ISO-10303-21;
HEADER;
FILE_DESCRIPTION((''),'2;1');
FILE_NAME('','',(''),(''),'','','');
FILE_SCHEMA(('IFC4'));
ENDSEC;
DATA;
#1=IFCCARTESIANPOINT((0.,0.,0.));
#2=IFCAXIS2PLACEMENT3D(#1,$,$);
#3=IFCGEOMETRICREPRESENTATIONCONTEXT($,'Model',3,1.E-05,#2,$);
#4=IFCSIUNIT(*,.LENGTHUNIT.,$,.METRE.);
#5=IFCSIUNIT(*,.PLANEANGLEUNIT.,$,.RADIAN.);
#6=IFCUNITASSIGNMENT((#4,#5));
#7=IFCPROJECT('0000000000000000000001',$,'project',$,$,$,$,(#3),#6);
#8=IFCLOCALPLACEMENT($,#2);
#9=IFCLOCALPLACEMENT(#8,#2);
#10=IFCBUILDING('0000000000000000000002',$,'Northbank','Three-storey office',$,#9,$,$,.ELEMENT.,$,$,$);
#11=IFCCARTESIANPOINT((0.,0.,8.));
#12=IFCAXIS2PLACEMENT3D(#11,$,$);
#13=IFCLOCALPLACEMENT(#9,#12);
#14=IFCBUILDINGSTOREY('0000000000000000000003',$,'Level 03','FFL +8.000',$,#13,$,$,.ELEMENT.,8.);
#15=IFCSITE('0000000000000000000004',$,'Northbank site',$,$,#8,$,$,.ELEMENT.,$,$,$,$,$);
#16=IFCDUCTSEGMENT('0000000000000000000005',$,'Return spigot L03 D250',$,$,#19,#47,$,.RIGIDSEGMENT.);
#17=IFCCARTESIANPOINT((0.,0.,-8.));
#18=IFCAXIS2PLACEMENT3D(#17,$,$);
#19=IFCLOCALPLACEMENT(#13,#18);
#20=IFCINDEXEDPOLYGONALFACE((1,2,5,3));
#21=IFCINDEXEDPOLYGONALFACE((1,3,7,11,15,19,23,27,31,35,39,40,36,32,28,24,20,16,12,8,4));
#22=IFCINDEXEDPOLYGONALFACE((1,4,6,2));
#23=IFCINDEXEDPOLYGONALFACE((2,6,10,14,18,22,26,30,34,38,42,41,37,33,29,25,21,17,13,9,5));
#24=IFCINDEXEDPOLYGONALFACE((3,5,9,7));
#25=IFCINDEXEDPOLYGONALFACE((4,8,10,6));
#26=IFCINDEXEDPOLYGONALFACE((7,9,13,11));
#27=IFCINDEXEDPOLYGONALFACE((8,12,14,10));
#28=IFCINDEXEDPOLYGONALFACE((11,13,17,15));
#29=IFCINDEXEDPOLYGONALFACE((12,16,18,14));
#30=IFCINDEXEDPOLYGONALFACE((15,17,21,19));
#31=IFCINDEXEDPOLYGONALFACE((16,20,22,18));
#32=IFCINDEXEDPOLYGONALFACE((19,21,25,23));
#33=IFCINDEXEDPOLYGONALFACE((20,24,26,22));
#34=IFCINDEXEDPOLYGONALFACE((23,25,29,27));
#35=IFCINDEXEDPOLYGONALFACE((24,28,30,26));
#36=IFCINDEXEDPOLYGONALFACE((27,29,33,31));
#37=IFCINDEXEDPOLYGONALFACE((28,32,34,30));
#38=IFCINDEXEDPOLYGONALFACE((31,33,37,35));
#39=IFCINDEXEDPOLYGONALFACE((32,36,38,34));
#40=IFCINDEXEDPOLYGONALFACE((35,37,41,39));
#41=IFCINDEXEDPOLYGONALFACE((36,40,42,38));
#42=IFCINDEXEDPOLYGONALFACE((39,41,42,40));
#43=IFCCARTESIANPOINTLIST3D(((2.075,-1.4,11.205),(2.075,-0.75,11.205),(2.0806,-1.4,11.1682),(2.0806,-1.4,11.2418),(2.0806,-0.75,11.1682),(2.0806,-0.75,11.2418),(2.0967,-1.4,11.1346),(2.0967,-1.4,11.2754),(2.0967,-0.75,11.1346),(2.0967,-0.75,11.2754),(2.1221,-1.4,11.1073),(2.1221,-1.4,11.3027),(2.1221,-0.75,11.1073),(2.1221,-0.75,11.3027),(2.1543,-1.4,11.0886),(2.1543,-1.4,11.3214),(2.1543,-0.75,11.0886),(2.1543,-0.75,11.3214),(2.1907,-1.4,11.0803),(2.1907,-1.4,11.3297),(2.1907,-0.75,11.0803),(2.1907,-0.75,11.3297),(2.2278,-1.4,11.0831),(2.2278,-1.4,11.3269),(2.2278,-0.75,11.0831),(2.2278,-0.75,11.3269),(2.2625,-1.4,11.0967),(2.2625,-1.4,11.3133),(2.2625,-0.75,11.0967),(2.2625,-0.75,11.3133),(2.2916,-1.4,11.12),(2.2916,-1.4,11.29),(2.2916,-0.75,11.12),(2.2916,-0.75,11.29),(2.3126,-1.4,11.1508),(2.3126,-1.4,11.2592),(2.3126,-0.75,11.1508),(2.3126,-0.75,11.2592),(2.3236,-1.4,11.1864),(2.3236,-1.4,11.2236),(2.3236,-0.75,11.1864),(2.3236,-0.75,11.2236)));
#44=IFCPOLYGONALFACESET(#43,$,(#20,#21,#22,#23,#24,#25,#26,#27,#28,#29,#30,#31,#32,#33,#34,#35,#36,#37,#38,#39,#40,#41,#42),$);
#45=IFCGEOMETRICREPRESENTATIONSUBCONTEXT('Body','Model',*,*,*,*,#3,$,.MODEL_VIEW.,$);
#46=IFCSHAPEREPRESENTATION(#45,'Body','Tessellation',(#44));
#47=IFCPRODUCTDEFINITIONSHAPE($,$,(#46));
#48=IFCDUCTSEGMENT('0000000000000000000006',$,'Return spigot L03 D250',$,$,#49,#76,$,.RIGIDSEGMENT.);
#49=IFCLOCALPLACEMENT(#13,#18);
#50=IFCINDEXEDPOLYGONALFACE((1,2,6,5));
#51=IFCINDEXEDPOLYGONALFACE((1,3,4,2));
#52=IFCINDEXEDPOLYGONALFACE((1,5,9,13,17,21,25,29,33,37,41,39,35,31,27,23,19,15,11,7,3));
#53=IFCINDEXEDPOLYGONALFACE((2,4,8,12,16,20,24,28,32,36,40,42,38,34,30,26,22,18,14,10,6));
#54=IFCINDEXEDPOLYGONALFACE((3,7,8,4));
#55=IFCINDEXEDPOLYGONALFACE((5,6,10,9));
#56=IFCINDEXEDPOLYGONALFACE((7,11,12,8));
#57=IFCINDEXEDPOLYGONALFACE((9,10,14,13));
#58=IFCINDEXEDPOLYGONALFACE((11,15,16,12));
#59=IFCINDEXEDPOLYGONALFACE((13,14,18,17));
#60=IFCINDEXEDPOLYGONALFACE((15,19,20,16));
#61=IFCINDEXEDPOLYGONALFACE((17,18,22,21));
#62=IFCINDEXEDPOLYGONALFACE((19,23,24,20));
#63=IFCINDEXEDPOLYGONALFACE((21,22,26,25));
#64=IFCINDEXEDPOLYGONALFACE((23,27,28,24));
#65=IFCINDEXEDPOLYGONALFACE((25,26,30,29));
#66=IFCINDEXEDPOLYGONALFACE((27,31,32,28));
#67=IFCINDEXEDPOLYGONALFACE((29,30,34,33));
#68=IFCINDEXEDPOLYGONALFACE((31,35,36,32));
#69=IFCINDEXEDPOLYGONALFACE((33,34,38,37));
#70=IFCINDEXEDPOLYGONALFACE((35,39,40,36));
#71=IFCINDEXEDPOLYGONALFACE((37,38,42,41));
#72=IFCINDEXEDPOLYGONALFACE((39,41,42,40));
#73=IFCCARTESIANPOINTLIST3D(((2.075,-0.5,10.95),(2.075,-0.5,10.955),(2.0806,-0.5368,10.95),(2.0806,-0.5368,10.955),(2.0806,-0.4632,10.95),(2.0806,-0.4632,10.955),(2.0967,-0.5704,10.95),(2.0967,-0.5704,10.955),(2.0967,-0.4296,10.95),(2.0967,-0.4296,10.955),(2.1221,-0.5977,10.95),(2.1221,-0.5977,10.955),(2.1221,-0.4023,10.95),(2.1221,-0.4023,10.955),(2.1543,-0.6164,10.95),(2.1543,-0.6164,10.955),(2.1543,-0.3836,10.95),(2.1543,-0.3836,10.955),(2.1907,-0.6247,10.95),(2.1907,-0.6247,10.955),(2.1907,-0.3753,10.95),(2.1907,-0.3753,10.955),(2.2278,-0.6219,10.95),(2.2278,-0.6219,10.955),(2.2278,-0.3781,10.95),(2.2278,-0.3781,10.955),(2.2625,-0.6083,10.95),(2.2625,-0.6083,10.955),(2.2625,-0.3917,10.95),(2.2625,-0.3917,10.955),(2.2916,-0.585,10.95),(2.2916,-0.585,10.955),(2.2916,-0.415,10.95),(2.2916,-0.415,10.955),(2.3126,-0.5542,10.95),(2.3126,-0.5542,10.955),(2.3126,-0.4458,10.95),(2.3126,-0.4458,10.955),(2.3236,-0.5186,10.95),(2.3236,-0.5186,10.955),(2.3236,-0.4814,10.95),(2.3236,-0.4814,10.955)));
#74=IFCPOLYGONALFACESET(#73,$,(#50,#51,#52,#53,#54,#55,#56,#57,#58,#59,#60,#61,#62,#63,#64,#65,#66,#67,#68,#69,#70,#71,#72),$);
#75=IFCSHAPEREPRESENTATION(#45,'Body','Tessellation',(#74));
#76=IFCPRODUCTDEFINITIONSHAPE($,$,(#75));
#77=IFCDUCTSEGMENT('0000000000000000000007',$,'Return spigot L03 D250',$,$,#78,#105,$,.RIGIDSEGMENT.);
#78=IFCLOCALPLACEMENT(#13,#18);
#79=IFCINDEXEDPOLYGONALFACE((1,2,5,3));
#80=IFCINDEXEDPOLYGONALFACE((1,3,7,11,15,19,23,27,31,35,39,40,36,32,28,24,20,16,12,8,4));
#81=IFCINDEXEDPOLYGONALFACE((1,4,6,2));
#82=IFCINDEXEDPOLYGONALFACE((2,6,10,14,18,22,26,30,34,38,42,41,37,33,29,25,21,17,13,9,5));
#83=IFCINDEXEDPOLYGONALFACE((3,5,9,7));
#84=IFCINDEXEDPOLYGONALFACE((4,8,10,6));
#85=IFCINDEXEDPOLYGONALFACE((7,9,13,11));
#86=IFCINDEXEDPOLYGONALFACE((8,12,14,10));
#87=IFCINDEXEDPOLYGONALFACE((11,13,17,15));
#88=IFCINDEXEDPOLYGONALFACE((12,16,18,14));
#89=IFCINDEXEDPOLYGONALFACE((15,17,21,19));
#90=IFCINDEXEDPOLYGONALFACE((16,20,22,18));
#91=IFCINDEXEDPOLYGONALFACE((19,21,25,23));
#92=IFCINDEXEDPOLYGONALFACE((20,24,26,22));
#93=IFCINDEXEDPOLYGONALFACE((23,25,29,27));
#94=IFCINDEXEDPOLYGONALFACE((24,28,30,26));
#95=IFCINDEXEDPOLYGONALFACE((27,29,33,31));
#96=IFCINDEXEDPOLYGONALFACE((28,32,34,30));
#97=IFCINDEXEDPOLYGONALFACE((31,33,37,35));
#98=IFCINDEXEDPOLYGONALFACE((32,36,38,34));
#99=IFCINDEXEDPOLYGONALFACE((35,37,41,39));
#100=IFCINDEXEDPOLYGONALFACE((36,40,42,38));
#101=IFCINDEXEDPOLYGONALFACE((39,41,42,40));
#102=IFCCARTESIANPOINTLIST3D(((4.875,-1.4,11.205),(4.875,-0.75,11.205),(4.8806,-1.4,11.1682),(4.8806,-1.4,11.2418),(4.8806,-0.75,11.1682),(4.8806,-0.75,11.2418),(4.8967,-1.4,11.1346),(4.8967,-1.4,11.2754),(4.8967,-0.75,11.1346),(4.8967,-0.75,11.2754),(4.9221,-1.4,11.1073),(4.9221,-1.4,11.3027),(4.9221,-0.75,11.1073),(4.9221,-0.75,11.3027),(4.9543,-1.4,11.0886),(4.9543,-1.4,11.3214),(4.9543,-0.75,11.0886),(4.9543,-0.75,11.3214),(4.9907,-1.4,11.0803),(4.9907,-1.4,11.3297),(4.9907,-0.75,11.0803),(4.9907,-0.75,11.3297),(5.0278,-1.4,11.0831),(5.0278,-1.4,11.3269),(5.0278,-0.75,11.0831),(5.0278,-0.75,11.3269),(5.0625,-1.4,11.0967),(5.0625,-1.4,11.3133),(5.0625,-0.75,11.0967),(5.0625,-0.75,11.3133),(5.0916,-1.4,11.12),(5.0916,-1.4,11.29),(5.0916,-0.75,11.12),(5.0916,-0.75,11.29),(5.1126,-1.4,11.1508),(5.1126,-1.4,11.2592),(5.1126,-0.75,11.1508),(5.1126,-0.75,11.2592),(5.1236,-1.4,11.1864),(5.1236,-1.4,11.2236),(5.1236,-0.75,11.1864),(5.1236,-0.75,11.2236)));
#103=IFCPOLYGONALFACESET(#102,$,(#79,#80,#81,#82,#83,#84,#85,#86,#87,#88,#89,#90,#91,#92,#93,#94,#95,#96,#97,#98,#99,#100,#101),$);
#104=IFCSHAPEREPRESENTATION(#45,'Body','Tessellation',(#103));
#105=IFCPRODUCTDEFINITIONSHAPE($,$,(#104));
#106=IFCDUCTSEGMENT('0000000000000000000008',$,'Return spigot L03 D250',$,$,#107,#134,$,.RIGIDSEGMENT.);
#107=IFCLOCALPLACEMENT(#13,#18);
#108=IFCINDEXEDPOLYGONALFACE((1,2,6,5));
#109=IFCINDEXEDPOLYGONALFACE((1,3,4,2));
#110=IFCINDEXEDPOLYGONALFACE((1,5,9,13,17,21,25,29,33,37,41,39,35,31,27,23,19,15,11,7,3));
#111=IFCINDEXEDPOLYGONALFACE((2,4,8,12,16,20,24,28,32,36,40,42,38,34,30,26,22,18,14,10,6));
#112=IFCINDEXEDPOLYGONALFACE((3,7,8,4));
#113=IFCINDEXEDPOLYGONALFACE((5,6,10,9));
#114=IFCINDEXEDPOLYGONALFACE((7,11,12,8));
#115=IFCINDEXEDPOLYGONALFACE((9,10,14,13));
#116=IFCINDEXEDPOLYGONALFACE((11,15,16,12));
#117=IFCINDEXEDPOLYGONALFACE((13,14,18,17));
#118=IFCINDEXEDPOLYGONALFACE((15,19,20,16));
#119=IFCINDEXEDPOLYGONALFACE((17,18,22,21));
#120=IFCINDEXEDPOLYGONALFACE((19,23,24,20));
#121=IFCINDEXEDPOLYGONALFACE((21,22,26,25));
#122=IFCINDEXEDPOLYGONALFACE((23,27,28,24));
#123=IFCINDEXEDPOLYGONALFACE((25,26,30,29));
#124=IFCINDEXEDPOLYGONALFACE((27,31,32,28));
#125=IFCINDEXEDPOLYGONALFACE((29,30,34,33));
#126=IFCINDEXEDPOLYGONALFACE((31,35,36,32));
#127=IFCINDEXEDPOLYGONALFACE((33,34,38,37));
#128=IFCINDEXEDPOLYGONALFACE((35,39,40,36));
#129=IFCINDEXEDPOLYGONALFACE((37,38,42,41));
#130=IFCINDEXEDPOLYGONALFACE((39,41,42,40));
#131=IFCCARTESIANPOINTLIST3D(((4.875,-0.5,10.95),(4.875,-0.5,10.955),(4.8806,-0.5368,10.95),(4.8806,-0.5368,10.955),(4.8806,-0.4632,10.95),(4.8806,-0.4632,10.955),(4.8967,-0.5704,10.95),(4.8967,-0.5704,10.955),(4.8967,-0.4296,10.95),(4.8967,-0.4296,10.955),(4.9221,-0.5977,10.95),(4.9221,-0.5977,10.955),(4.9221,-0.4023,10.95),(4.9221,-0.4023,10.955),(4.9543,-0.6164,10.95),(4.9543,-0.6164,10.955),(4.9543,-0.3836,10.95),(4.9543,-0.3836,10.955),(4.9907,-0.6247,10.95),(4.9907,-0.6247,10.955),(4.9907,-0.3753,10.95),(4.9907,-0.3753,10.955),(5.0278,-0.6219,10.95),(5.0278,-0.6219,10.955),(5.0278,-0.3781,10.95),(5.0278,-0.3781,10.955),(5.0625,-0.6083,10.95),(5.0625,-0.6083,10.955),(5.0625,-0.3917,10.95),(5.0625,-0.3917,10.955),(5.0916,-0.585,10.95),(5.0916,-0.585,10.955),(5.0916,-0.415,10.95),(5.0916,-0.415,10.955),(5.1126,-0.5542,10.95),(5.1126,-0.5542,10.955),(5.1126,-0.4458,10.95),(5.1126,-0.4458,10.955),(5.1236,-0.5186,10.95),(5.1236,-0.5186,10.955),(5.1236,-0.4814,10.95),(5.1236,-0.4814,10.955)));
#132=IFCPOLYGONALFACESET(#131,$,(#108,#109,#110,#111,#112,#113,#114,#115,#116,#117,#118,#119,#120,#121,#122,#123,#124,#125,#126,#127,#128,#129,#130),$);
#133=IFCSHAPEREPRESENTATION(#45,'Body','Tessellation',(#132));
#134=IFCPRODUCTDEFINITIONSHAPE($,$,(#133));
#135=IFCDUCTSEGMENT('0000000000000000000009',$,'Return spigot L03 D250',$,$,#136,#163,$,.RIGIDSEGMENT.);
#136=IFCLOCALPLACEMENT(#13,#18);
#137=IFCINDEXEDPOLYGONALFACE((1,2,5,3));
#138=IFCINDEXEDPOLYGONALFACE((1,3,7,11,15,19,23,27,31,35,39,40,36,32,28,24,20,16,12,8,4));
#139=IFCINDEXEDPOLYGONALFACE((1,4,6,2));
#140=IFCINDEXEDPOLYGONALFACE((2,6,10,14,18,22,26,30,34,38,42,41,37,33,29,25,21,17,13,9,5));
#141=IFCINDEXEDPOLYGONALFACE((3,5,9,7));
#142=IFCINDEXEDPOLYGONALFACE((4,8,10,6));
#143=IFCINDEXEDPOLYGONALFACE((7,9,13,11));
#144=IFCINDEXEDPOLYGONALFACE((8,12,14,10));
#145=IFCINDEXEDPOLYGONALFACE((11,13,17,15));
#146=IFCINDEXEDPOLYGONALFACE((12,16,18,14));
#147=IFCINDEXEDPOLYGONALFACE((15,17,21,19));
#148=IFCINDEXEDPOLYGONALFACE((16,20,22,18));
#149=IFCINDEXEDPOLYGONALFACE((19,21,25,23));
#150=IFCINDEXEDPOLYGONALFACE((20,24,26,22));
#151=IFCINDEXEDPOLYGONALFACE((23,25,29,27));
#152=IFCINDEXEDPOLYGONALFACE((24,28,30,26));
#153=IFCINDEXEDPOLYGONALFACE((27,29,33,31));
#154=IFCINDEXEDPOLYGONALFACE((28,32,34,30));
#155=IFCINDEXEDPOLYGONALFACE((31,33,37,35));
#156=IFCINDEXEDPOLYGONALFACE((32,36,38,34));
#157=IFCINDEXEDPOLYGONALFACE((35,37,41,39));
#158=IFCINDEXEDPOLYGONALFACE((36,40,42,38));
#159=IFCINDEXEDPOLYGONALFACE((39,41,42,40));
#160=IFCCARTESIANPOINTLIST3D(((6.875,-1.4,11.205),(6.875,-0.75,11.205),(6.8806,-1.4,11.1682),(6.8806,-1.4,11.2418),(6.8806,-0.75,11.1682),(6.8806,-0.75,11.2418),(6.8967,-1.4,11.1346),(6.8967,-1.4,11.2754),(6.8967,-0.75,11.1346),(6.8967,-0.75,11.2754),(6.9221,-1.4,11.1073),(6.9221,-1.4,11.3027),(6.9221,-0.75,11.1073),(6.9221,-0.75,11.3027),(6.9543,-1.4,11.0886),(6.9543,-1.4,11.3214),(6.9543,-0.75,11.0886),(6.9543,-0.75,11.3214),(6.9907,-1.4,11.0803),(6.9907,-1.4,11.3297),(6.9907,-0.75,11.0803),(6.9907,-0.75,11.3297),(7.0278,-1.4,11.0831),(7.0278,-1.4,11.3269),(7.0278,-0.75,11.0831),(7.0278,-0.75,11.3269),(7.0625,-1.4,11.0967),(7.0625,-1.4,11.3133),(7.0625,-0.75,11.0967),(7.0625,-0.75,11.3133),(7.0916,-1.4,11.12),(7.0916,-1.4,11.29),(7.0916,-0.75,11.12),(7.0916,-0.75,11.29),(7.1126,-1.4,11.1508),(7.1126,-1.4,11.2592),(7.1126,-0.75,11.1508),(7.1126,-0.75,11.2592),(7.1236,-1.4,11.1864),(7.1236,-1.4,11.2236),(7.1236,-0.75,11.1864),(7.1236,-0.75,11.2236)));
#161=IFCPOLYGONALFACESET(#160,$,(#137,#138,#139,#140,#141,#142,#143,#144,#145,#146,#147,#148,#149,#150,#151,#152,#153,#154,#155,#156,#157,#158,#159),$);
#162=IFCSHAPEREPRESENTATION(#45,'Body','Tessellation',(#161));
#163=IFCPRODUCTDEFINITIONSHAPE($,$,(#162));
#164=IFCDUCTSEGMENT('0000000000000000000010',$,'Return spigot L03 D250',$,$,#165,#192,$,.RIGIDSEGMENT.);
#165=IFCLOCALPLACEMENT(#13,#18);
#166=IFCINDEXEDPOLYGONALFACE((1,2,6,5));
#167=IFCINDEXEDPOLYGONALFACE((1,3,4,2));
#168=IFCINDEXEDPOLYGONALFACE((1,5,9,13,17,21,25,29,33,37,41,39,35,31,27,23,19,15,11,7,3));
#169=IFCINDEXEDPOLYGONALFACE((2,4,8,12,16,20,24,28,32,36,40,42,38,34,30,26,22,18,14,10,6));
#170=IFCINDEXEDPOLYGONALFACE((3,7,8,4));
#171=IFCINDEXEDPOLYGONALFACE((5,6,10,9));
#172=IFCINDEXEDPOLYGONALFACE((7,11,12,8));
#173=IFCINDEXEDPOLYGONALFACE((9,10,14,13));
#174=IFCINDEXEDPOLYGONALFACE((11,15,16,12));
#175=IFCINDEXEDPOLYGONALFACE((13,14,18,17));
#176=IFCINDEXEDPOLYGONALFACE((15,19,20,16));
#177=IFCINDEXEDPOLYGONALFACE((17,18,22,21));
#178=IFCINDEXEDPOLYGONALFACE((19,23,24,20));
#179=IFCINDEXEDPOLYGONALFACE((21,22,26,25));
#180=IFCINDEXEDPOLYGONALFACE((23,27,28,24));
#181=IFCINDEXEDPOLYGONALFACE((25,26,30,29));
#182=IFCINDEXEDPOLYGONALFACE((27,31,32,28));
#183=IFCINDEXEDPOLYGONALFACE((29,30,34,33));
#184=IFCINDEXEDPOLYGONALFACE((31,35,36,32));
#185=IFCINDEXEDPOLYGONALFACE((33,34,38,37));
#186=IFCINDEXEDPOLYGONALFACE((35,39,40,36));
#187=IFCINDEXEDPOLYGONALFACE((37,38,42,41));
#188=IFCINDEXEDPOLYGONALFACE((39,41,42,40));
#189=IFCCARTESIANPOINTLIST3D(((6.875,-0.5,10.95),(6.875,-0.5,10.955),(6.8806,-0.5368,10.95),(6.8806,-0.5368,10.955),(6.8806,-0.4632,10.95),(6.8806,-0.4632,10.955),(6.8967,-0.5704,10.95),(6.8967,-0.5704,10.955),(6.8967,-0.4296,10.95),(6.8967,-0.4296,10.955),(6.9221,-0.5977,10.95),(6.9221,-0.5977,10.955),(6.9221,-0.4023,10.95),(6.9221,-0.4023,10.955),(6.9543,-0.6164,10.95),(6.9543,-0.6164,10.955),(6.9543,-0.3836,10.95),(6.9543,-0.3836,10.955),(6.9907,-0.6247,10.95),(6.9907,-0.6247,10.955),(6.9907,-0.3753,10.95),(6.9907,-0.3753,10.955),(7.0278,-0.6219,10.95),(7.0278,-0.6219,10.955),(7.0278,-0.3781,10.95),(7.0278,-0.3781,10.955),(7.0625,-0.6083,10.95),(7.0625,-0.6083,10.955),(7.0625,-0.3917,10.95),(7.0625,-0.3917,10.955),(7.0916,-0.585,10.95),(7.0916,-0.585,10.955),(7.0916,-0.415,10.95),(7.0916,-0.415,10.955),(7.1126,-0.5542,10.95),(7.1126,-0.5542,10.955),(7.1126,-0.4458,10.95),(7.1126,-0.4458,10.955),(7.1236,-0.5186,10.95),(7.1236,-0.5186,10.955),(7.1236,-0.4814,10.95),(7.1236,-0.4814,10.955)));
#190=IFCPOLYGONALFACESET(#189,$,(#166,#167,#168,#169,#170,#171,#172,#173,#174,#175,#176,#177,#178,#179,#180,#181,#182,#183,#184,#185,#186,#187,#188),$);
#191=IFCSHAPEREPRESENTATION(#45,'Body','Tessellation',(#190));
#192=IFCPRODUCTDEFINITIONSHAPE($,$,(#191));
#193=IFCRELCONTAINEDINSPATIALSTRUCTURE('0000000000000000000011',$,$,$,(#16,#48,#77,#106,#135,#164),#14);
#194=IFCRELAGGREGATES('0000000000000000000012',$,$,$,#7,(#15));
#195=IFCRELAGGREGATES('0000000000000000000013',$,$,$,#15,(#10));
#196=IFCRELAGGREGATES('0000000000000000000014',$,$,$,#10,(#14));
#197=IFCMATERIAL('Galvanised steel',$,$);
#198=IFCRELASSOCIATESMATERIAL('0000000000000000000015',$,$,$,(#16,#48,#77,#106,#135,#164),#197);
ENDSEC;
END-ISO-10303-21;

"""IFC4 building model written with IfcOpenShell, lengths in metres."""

from ifc_helpers import new_model, si_unit, frame, origin, place, context, subcontext, project, spatial, circle, extrude, material, element, save


model = new_model("IFC4")

# Units and contexts
model_context = context("Model", 3, precision=1e-05, world=origin())
body_context = subcontext(model_context, "Body", "Model", "MODEL_VIEW")
ifc_project = project(units=[si_unit("LENGTHUNIT", "METRE"), si_unit("PLANEANGLEUNIT", "RADIAN")], contexts=[model_context])

# Site, building, storey
site_placement = place(None, origin())
site = spatial("IfcSite", under=ifc_project, at=site_placement, Name="Northbank site", CompositionType="ELEMENT")
building_placement = place(site_placement, origin())
building = spatial("IfcBuilding", under=site, at=building_placement, Name="Northbank", Description="Three-storey office", CompositionType="ELEMENT")
storey_placement = place(building_placement, frame((0.0, 0.0, 8.0)))
storey = spatial("IfcBuildingStorey", under=building, at=storey_placement, Name="Level 03", Description="FFL +8.000", CompositionType="ELEMENT", Elevation=8.0)

# Shared definitions
ifc_material_1 = material(Name="Galvanised steel")

# Duct segments
duct_segment_1_placement = place(storey_placement, frame((0.0, 0.0, -8.0)))
element("IfcDuctSegment", 1, at=duct_segment_1_placement, inside=storey, material=ifc_material_1, Name="Return spigot L03 D250", PredefinedType="RIGIDSEGMENT", context=body_context, shape_type="SweptSolid", body=[
    extrude(circle(Radius=0.125), frame((2.2, -1.4, 11.205), z_axis=(0.0, 1.0, 0.0), x_axis=(-1.0, 0.0, 0.0)), (0.0, 0.0, 1.0), 0.65),
])
duct_segment_2_placement = place(storey_placement, frame((0.0, 0.0, -8.0)))
element("IfcDuctSegment", 2, at=duct_segment_2_placement, inside=storey, material=ifc_material_1, Name="Return spigot L03 D250", PredefinedType="RIGIDSEGMENT", context=body_context, shape_type="SweptSolid", body=[
    extrude(circle(Radius=0.125), frame((2.2, -0.5, 10.955), z_axis=(0.0, 0.0, -1.0), x_axis=(-1.0, 0.0, 0.0)), (0.0, 0.0, 1.0), 0.005),
])

# Duct segments
duct_segment_3_placement = place(storey_placement, frame((0.0, 0.0, -8.0)))
element("IfcDuctSegment", 3, at=duct_segment_3_placement, inside=storey, material=ifc_material_1, Name="Return spigot L03 D250", PredefinedType="RIGIDSEGMENT", context=body_context, shape_type="SweptSolid", body=[
    extrude(circle(Radius=0.125), frame((5.0, -1.4, 11.205), z_axis=(0.0, 1.0, 0.0), x_axis=(-1.0, 0.0, 0.0)), (0.0, 0.0, 1.0), 0.65),
])
duct_segment_4_placement = place(storey_placement, frame((0.0, 0.0, -8.0)))
element("IfcDuctSegment", 4, at=duct_segment_4_placement, inside=storey, material=ifc_material_1, Name="Return spigot L03 D250", PredefinedType="RIGIDSEGMENT", context=body_context, shape_type="SweptSolid", body=[
    extrude(circle(Radius=0.125), frame((5.0, -0.5, 10.955), z_axis=(0.0, 0.0, -1.0), x_axis=(-1.0, 0.0, 0.0)), (0.0, 0.0, 1.0), 0.005),
])

# Duct segments
duct_segment_5_placement = place(storey_placement, frame((0.0, 0.0, -8.0)))
element("IfcDuctSegment", 5, at=duct_segment_5_placement, inside=storey, material=ifc_material_1, Name="Return spigot L03 D250", PredefinedType="RIGIDSEGMENT", context=body_context, shape_type="SweptSolid", body=[
    extrude(circle(Radius=0.125), frame((7.0, -1.4, 11.205), z_axis=(0.0, 1.0, 0.0), x_axis=(-1.0, 0.0, 0.0)), (0.0, 0.0, 1.0), 0.65),
])
duct_segment_6_placement = place(storey_placement, frame((0.0, 0.0, -8.0)))
element("IfcDuctSegment", 6, at=duct_segment_6_placement, inside=storey, material=ifc_material_1, Name="Return spigot L03 D250", PredefinedType="RIGIDSEGMENT", context=body_context, shape_type="SweptSolid", body=[
    extrude(circle(Radius=0.125), frame((7.0, -0.5, 10.955), z_axis=(0.0, 0.0, -1.0), x_axis=(-1.0, 0.0, 0.0)), (0.0, 0.0, 1.0), 0.005),
])

save(model, "model.ifc")
